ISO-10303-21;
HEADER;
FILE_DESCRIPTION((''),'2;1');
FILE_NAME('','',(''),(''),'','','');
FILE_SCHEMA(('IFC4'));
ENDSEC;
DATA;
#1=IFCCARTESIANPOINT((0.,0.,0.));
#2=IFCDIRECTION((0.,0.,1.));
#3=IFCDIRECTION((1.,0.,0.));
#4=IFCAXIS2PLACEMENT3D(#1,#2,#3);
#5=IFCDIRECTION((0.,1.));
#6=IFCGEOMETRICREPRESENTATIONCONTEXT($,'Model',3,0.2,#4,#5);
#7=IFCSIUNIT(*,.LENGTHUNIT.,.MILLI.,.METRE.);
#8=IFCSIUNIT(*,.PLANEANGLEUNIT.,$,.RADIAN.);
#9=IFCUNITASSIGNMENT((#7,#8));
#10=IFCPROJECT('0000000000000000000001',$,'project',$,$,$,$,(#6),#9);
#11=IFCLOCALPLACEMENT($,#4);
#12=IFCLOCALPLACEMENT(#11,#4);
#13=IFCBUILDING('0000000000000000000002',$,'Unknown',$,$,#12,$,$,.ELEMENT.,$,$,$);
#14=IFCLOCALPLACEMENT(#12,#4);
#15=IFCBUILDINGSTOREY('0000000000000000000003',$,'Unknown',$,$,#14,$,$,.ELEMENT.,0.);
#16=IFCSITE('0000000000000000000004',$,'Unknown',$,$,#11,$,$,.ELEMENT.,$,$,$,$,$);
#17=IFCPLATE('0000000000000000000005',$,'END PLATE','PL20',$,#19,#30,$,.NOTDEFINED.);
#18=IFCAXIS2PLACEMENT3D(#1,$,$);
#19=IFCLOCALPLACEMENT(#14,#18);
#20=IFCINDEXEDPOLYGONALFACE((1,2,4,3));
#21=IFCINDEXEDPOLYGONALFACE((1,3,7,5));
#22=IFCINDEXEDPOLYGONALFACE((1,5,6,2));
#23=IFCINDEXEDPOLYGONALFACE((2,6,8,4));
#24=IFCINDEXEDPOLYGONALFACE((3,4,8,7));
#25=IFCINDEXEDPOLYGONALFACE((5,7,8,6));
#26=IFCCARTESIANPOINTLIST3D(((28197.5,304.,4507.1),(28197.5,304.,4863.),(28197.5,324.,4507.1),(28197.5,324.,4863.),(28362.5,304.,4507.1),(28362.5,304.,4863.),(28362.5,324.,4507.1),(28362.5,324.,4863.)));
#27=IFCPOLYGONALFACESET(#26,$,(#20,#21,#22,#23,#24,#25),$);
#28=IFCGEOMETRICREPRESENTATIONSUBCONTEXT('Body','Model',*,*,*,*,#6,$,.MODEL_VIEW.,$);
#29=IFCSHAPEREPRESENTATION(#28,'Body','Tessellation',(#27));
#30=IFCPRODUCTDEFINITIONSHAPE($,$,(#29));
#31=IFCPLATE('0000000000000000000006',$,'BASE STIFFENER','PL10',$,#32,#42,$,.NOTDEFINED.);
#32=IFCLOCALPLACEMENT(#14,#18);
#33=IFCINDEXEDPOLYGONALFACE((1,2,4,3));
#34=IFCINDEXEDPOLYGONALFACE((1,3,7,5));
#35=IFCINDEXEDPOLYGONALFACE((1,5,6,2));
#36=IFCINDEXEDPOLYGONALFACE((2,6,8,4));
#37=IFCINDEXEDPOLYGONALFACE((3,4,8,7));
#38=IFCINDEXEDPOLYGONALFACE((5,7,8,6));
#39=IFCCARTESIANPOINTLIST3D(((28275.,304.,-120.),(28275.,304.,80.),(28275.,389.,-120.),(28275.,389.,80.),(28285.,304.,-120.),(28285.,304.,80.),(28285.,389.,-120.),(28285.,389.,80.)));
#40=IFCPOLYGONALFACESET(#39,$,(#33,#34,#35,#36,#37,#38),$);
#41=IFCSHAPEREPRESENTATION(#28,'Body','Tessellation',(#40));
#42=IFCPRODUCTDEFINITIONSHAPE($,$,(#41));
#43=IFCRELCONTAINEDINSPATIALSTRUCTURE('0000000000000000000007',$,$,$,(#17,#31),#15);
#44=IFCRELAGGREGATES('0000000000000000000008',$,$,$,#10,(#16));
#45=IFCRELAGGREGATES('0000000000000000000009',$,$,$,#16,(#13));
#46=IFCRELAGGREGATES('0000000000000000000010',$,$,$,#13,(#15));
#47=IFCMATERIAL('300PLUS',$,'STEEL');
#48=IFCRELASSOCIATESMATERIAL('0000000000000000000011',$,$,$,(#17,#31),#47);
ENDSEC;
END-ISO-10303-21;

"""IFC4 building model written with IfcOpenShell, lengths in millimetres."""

from ifc_helpers import new_model, si_unit, direction, frame, origin_with_axes, place, context, subcontext, project, spatial, line, indexed_curve, outline, extrude, material, element, save


model = new_model("IFC4")

# Units and contexts
model_context = context("Model", 3, precision=0.2, world=origin_with_axes(), true_north=direction((0.0, 1.0)))
body_context = subcontext(model_context, "Body", "Model", "MODEL_VIEW")
ifc_project = project(units=[si_unit("LENGTHUNIT", "METRE", prefix="MILLI"), si_unit("PLANEANGLEUNIT", "RADIAN")], contexts=[model_context])

# Site, building, storey
site_placement = place(None, origin_with_axes())
site = spatial("IfcSite", under=ifc_project, at=site_placement, Name="Unknown", CompositionType="ELEMENT")
building_placement = place(site_placement, origin_with_axes())
building = spatial("IfcBuilding", under=site, at=building_placement, Name="Unknown", CompositionType="ELEMENT")
storey_placement = place(building_placement, origin_with_axes())
storey = spatial("IfcBuildingStorey", under=building, at=storey_placement, Name="Unknown", CompositionType="ELEMENT", Elevation=0.0)

# Shared definitions
ifc_material_1 = material(Name="300PLUS", Category="STEEL")

# Plates
plate_1_placement = place(storey_placement, frame((28197.5, 314.0, 4507.1), z_axis=(0.0, -1.0, 0.0), x_axis=(1.0, 0.0, 0.0)))
element("IfcPlate", 1, at=plate_1_placement, inside=storey, material=ifc_material_1, Name="END PLATE", Description="PL20", PredefinedType="NOTDEFINED", context=body_context, shape_type="SolidModel", body=[
    extrude(outline(indexed_curve([(0.0, 0.0), (165.0, 0.0), (165.0, 355.9), (0.0, 355.9)], segments=[line(1, 2, 3, 4, 1)])), frame((0.0, 0.0, 10.0), z_axis=(0.0, 0.0, 1.0), x_axis=(1.0, 0.0, 0.0)), (0.0, 0.0, -1.0), 20.0),
])
plate_2_placement = place(storey_placement, frame((28280.0, 304.0, -120.0), z_axis=(1.0, 0.0, 0.0), x_axis=(0.0, 1.0, 0.0)))
element("IfcPlate", 2, at=plate_2_placement, inside=storey, material=ifc_material_1, Name="BASE STIFFENER", Description="PL10", PredefinedType="NOTDEFINED", context=body_context, shape_type="SolidModel", body=[
    extrude(outline(indexed_curve([(0.0, 0.0), (85.0, 0.0), (85.0, 200.0), (0.0, 200.0)], segments=[line(1, 2, 3, 4, 1)])), frame((0.0, 0.0, 5.0), z_axis=(0.0, 0.0, 1.0), x_axis=(1.0, 0.0, 0.0)), (0.0, 0.0, -1.0), 10.0),
])

save(model, "model.ifc")
